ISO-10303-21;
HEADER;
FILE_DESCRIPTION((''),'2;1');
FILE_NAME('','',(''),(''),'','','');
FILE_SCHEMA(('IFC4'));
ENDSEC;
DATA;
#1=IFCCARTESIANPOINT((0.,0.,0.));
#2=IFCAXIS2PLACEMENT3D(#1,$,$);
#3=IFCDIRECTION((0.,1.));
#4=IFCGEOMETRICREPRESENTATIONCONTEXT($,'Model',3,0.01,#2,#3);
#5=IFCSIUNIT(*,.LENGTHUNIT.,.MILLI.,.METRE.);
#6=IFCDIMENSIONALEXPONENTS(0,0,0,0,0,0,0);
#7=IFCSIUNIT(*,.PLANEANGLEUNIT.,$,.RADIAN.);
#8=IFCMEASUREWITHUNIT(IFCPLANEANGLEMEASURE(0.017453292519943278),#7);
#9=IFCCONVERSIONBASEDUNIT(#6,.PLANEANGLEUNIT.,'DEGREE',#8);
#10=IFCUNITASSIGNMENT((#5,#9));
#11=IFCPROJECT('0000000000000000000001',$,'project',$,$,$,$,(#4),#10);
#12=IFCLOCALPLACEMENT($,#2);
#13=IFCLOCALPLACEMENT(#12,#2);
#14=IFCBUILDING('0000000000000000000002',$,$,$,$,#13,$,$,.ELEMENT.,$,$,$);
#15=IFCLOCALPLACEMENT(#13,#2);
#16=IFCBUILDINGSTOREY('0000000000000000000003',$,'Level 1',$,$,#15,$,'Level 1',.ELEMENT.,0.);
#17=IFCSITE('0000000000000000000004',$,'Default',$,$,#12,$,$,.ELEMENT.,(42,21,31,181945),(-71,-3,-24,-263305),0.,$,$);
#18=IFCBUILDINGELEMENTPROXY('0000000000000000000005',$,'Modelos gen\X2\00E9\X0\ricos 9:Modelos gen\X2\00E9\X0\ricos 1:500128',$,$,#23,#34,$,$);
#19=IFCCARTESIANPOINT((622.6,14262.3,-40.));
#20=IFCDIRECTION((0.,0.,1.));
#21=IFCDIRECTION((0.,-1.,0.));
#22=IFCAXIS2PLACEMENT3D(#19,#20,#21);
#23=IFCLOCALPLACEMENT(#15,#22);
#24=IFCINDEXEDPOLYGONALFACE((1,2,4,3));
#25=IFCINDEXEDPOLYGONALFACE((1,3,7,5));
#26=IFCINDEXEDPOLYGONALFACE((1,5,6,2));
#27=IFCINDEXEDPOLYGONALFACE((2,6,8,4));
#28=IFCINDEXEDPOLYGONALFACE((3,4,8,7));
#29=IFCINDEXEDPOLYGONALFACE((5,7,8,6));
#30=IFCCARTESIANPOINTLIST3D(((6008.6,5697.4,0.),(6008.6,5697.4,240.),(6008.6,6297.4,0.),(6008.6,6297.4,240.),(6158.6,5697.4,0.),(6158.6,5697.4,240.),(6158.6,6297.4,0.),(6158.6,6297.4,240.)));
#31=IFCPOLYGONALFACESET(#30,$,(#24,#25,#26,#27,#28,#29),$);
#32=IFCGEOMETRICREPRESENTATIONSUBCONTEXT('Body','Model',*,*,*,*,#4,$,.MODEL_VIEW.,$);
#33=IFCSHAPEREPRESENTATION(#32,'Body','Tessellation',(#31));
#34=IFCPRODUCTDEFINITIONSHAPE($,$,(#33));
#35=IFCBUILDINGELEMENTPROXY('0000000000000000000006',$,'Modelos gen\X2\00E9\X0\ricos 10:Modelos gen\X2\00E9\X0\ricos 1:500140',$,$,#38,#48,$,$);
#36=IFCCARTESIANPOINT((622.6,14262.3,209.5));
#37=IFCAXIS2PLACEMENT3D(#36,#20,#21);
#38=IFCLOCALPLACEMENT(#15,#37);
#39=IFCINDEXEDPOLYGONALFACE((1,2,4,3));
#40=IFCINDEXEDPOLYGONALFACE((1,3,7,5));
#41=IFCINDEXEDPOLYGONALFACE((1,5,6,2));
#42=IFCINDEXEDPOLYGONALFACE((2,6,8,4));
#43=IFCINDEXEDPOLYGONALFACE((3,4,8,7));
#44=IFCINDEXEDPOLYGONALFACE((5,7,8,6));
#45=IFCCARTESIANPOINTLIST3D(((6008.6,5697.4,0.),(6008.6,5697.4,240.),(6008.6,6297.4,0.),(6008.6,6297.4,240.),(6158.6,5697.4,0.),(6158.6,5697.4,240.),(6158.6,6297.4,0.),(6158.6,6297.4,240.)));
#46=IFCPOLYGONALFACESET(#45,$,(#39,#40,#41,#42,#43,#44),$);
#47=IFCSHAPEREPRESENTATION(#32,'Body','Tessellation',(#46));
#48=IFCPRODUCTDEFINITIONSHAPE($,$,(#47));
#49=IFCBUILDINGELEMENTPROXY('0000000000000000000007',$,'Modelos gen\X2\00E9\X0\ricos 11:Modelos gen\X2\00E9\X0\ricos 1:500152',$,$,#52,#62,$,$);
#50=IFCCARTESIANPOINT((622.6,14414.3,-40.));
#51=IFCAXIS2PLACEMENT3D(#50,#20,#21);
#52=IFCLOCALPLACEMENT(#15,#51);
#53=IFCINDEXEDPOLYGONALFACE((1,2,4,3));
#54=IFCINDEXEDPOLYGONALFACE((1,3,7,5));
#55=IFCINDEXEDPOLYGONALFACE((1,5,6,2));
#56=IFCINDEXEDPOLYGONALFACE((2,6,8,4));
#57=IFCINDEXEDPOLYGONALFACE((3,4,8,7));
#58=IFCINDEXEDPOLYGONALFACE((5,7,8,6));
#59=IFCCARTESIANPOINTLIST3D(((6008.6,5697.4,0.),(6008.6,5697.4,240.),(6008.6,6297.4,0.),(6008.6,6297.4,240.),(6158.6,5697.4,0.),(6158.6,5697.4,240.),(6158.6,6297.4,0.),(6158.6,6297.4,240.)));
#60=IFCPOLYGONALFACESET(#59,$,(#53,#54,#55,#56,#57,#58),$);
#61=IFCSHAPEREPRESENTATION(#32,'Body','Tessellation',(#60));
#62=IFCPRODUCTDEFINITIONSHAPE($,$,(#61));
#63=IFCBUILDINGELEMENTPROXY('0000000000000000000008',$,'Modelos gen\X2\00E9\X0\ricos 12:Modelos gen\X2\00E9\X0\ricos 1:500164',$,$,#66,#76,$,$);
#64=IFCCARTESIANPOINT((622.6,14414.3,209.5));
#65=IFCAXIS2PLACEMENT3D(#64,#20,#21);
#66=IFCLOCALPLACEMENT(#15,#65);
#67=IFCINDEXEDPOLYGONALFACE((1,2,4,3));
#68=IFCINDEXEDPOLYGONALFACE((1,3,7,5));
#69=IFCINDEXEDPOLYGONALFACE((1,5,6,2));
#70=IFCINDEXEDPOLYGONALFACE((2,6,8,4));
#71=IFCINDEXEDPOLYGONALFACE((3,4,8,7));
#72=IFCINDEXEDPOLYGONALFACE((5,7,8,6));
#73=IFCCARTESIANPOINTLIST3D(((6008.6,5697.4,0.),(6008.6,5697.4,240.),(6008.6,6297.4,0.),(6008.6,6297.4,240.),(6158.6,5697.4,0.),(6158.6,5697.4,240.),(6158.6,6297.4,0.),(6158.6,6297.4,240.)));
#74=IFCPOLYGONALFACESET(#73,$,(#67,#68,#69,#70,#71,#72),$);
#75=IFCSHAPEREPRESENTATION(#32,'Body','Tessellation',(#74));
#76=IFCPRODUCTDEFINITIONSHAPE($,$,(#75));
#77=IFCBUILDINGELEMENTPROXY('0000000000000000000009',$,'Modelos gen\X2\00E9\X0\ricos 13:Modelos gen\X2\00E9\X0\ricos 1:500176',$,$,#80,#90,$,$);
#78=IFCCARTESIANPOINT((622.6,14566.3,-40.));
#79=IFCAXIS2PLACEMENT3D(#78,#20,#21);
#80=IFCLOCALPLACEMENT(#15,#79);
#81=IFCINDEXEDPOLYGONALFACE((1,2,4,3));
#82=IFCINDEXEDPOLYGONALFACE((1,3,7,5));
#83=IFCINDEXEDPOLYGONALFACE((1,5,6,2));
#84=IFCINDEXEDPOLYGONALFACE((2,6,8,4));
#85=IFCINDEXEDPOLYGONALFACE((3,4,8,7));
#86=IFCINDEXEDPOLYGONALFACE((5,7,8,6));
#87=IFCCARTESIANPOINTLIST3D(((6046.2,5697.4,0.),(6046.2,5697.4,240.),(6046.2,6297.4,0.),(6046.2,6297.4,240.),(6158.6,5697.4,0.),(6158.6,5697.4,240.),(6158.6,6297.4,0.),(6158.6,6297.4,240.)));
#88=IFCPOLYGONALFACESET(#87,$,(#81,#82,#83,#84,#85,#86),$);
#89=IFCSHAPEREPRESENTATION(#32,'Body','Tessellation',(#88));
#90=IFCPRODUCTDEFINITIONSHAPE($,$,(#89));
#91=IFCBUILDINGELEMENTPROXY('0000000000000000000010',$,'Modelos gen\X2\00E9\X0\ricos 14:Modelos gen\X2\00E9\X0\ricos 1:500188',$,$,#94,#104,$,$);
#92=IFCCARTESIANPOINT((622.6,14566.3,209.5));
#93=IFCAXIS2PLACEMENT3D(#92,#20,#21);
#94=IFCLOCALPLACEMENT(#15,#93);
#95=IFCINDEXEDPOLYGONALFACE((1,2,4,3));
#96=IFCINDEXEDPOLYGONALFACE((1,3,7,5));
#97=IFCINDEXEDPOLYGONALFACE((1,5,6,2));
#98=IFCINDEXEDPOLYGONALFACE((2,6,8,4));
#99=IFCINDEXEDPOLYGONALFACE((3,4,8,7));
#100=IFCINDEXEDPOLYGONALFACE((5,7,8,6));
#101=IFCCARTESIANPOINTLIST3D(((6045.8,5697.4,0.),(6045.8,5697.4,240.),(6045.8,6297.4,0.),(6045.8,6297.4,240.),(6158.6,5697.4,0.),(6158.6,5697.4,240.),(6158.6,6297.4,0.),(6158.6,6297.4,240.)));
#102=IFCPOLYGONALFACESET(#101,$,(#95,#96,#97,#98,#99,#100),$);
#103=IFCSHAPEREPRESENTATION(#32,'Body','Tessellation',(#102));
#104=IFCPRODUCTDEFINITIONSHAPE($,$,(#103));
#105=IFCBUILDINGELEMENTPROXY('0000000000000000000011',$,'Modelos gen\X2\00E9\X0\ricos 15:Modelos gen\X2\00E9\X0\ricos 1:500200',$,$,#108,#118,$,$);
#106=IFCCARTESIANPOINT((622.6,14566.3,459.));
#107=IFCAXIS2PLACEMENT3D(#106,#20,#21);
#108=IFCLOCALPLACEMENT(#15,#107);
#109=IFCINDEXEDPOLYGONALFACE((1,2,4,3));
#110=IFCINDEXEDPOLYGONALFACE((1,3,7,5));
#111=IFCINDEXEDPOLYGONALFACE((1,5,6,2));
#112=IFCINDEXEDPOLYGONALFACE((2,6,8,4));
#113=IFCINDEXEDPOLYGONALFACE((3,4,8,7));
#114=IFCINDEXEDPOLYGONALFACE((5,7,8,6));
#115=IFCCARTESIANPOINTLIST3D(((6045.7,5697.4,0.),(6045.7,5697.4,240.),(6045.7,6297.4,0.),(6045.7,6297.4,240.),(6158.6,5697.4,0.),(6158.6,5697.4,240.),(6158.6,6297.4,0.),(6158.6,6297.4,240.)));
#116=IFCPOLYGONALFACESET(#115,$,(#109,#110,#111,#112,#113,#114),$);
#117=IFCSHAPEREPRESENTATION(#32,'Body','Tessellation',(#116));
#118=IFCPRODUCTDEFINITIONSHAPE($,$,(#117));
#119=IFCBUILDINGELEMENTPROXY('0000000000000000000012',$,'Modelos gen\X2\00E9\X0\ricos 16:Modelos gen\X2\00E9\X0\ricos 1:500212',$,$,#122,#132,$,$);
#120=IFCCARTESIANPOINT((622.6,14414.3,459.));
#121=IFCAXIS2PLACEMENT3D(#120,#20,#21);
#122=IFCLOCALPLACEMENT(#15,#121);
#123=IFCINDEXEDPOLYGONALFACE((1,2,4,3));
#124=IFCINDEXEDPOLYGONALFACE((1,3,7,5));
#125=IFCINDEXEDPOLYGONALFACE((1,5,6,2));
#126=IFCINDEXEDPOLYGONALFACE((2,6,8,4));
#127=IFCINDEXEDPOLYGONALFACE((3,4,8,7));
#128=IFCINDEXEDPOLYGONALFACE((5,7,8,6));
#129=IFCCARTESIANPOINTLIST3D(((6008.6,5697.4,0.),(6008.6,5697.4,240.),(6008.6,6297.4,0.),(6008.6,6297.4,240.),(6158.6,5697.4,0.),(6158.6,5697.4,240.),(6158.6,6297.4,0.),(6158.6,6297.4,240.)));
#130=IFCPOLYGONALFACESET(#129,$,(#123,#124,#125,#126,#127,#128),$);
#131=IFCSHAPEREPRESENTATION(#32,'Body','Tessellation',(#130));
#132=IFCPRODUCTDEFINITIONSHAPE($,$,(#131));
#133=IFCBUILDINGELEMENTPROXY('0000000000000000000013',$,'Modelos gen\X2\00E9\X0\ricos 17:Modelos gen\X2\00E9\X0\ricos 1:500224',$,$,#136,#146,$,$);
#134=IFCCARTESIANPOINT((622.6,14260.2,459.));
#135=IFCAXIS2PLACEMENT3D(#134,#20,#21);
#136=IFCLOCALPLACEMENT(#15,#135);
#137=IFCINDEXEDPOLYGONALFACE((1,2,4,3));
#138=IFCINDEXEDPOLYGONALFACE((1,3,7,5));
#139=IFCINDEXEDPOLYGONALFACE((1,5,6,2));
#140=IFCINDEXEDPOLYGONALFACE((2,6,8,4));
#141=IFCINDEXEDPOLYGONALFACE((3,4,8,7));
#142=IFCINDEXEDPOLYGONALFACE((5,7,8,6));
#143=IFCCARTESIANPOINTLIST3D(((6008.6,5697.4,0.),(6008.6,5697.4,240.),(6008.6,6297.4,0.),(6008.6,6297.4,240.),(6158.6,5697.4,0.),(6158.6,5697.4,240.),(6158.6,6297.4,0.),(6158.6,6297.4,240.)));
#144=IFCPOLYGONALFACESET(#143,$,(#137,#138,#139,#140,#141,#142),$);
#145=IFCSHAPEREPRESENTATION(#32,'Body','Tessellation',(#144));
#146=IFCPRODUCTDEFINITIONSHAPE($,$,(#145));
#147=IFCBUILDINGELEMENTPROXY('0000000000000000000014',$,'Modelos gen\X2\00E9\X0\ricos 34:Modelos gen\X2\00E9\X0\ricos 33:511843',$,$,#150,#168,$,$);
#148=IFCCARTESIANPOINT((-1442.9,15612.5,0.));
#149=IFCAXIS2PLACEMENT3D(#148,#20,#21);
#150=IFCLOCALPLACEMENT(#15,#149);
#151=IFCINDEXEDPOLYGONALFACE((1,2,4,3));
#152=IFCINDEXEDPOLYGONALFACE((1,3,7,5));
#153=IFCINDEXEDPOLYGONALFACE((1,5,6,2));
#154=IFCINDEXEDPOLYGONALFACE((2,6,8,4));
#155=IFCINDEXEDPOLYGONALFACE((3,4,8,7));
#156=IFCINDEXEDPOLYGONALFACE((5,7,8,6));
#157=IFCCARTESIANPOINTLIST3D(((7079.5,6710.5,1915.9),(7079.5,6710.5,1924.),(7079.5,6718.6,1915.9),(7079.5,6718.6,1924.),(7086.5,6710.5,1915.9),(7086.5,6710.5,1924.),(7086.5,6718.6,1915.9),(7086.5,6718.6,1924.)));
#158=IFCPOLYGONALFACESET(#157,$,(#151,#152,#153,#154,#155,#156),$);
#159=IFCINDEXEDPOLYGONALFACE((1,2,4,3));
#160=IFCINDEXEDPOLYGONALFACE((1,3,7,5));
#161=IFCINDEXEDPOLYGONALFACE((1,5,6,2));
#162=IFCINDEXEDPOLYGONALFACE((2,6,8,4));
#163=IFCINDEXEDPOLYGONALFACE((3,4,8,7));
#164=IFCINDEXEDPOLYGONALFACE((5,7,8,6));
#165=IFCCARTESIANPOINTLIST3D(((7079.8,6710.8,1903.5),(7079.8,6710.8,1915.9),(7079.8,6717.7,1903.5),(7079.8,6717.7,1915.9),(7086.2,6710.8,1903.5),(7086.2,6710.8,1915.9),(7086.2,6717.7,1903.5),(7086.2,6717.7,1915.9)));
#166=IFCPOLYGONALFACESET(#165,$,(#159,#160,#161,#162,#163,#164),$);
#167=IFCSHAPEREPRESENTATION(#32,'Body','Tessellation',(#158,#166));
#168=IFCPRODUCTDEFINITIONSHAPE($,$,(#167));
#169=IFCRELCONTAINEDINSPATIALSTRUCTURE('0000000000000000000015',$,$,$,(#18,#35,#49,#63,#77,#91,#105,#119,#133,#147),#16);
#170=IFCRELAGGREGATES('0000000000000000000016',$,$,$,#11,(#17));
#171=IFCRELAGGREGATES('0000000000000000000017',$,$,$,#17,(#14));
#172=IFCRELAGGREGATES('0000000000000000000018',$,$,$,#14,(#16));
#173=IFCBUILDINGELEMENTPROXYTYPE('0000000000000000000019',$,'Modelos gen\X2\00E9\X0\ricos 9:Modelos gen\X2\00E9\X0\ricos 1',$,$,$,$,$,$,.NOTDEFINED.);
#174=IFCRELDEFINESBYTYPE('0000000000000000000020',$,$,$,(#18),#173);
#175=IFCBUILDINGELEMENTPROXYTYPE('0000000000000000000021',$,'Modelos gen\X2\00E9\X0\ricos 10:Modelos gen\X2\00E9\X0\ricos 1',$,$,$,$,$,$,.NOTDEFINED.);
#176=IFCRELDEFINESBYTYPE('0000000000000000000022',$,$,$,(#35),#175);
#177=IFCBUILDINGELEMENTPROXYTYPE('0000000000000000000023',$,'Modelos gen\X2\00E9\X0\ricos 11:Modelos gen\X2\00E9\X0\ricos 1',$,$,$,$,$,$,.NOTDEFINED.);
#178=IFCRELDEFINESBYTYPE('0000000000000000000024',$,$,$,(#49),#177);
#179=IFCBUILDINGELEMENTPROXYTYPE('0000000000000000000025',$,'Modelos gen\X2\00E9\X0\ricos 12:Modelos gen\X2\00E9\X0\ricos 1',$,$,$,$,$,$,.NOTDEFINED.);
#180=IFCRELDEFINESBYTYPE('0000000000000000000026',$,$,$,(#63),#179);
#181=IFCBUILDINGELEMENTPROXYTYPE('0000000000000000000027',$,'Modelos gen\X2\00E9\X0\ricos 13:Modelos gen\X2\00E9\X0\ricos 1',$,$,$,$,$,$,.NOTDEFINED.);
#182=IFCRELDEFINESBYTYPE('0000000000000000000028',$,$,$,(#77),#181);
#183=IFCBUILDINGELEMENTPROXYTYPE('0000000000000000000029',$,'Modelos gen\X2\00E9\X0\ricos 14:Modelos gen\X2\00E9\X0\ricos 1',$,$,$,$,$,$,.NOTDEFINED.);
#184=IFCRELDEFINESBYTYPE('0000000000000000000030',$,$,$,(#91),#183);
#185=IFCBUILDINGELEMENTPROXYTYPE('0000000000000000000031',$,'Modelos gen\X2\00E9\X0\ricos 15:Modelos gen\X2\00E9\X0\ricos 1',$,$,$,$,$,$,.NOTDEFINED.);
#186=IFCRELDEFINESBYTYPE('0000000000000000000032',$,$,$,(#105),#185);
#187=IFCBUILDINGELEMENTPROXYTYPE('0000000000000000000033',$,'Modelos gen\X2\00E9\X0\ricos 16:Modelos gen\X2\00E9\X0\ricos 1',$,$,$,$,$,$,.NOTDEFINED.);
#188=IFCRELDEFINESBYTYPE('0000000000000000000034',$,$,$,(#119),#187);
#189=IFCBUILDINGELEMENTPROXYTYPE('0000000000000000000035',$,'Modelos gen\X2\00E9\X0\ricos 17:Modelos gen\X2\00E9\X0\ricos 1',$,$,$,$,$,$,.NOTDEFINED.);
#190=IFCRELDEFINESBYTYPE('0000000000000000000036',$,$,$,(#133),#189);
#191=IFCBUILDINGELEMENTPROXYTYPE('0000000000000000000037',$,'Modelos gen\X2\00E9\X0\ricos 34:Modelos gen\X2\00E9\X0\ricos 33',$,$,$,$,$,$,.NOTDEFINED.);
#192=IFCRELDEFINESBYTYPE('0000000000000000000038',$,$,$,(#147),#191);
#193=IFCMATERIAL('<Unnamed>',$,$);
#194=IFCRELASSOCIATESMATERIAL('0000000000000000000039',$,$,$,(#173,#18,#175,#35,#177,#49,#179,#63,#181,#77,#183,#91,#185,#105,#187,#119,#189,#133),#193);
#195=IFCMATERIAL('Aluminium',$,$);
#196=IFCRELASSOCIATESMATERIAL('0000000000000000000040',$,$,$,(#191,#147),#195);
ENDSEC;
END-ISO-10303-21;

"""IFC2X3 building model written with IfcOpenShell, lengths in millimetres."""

from ifc_helpers import new_model, entity, si_unit, converted_unit, direction, frame, frame_2d, origin, origin_2d_with_axis, place, context, subcontext, project, spatial, rectangle, extrude, source, transform, mapped, material, type_object, type_shapes, element, save


model = new_model("IFC2X3")

# Units and contexts
model_context = context("Model", 3, precision=0.01, world=origin(), true_north=direction((0.0, 1.0)))
body_context = subcontext(model_context, "Body", "Model", "MODEL_VIEW")
ifc_project = project(units=[si_unit("LENGTHUNIT", "METRE", prefix="MILLI"), converted_unit("PLANEANGLEUNIT", "DEGREE", entity("IfcPlaneAngleMeasure", 0.017453292519943278), si_unit("PLANEANGLEUNIT", "RADIAN"), dimensions=[0, 0, 0, 0, 0, 0, 0])], contexts=[model_context])

# Site, building, storey
site_placement = place(None, origin())
site = spatial("IfcSite", under=ifc_project, at=site_placement, Name="Default", CompositionType="ELEMENT", RefLatitude=(42, 21, 31, 181945), RefLongitude=(-71, -3, -24, -263305), RefElevation=0.0)
building_placement = place(site_placement, origin())
building = spatial("IfcBuilding", under=site, at=building_placement, CompositionType="ELEMENT")
storey_placement = place(building_placement, origin())
storey = spatial("IfcBuildingStorey", under=building, at=storey_placement, Name="Level 1", LongName="Level 1", CompositionType="ELEMENT", Elevation=0.0)

# Building element proxies
ifc_material_1 = material(Name="<Unnamed>")
building_element_proxy_type_1 = type_object("IfcBuildingElementProxyType", Name="Modelos genéricos 9:Modelos genéricos 1", PredefinedType="NOTDEFINED", material=ifc_material_1)
shared_shape_1 = source(origin(), body_context, "Body", "SweptSolid", [
    extrude(rectangle(XDim=150.0, YDim=600.0, at=origin_2d_with_axis()), frame((6083.6, 5997.4, 0.0), z_axis=(0.0, 0.0, 1.0), x_axis=(-1.0, 0.0, 0.0)), (0.0, 0.0, 1.0), 240.0),
])
type_shapes(building_element_proxy_type_1, [shared_shape_1])
proxy_1_placement = place(storey_placement, frame((622.6, 14262.3, -40.0), z_axis=(0.0, 0.0, 1.0), x_axis=(0.0, -1.0, 0.0)))
element("IfcBuildingElementProxy", 1, at=proxy_1_placement, inside=storey, type_object=building_element_proxy_type_1, material=ifc_material_1, Name="Modelos genéricos 9:Modelos genéricos 1:500128", context=body_context, shape_type="MappedRepresentation", body=[
    mapped(shared_shape_1, transform((0.0, 0.0, 0.0), scale=1.0)),
])
building_element_proxy_type_2 = type_object("IfcBuildingElementProxyType", Name="Modelos genéricos 10:Modelos genéricos 1", PredefinedType="NOTDEFINED", material=ifc_material_1)
shared_shape_2 = source(origin(), body_context, "Body", "SweptSolid", [
    extrude(rectangle(XDim=150.0, YDim=600.0, at=origin_2d_with_axis()), frame((6083.6, 5997.4, 0.0), z_axis=(0.0, 0.0, 1.0), x_axis=(-1.0, 0.0, 0.0)), (0.0, 0.0, 1.0), 240.0),
])
type_shapes(building_element_proxy_type_2, [shared_shape_2])
proxy_2_placement = place(storey_placement, frame((622.6, 14262.3, 209.5), z_axis=(0.0, 0.0, 1.0), x_axis=(0.0, -1.0, 0.0)))
element("IfcBuildingElementProxy", 2, at=proxy_2_placement, inside=storey, type_object=building_element_proxy_type_2, material=ifc_material_1, Name="Modelos genéricos 10:Modelos genéricos 1:500140", context=body_context, shape_type="MappedRepresentation", body=[
    mapped(shared_shape_2, transform((0.0, 0.0, 0.0), scale=1.0)),
])
building_element_proxy_type_3 = type_object("IfcBuildingElementProxyType", Name="Modelos genéricos 11:Modelos genéricos 1", PredefinedType="NOTDEFINED", material=ifc_material_1)
shared_shape_3 = source(origin(), body_context, "Body", "SweptSolid", [
    extrude(rectangle(XDim=150.0, YDim=600.0, at=origin_2d_with_axis()), frame((6083.6, 5997.4, 0.0), z_axis=(0.0, 0.0, 1.0), x_axis=(-1.0, 0.0, 0.0)), (0.0, 0.0, 1.0), 240.0),
])
type_shapes(building_element_proxy_type_3, [shared_shape_3])
proxy_3_placement = place(storey_placement, frame((622.6, 14414.3, -40.0), z_axis=(0.0, 0.0, 1.0), x_axis=(0.0, -1.0, 0.0)))
element("IfcBuildingElementProxy", 3, at=proxy_3_placement, inside=storey, type_object=building_element_proxy_type_3, material=ifc_material_1, Name="Modelos genéricos 11:Modelos genéricos 1:500152", context=body_context, shape_type="MappedRepresentation", body=[
    mapped(shared_shape_3, transform((0.0, 0.0, 0.0), scale=1.0)),
])
building_element_proxy_type_4 = type_object("IfcBuildingElementProxyType", Name="Modelos genéricos 12:Modelos genéricos 1", PredefinedType="NOTDEFINED", material=ifc_material_1)
shared_shape_4 = source(origin(), body_context, "Body", "SweptSolid", [
    extrude(rectangle(XDim=150.0, YDim=600.0, at=origin_2d_with_axis()), frame((6083.6, 5997.4, 0.0), z_axis=(0.0, 0.0, 1.0), x_axis=(-1.0, 0.0, 0.0)), (0.0, 0.0, 1.0), 240.0),
])
type_shapes(building_element_proxy_type_4, [shared_shape_4])
proxy_4_placement = place(storey_placement, frame((622.6, 14414.3, 209.5), z_axis=(0.0, 0.0, 1.0), x_axis=(0.0, -1.0, 0.0)))
element("IfcBuildingElementProxy", 4, at=proxy_4_placement, inside=storey, type_object=building_element_proxy_type_4, material=ifc_material_1, Name="Modelos genéricos 12:Modelos genéricos 1:500164", context=body_context, shape_type="MappedRepresentation", body=[
    mapped(shared_shape_4, transform((0.0, 0.0, 0.0), scale=1.0)),
])
building_element_proxy_type_5 = type_object("IfcBuildingElementProxyType", Name="Modelos genéricos 13:Modelos genéricos 1", PredefinedType="NOTDEFINED", material=ifc_material_1)
shared_shape_5 = source(origin(), body_context, "Body", "SweptSolid", [
    extrude(rectangle(XDim=112.4, YDim=600.0, at=frame_2d((0.0, 0.0), x_axis=(1.0, 0.0))), frame((6102.4, 5997.4, 0.0), z_axis=(0.0, 0.0, 1.0), x_axis=(-1.0, 0.0, 0.0)), (0.0, 0.0, 1.0), 240.0),
])
type_shapes(building_element_proxy_type_5, [shared_shape_5])
proxy_5_placement = place(storey_placement, frame((622.6, 14566.3, -40.0), z_axis=(0.0, 0.0, 1.0), x_axis=(0.0, -1.0, 0.0)))
element("IfcBuildingElementProxy", 5, at=proxy_5_placement, inside=storey, type_object=building_element_proxy_type_5, material=ifc_material_1, Name="Modelos genéricos 13:Modelos genéricos 1:500176", context=body_context, shape_type="MappedRepresentation", body=[
    mapped(shared_shape_5, transform((0.0, 0.0, 0.0), scale=1.0)),
])
building_element_proxy_type_6 = type_object("IfcBuildingElementProxyType", Name="Modelos genéricos 14:Modelos genéricos 1", PredefinedType="NOTDEFINED", material=ifc_material_1)
shared_shape_6 = source(origin(), body_context, "Body", "SweptSolid", [
    extrude(rectangle(XDim=112.8, YDim=600.0, at=frame_2d((0.0, 0.0), x_axis=(1.0, 0.0))), frame((6102.2, 5997.4, 0.0), z_axis=(0.0, 0.0, 1.0), x_axis=(-1.0, 0.0, 0.0)), (0.0, 0.0, 1.0), 240.0),
])
type_shapes(building_element_proxy_type_6, [shared_shape_6])
proxy_6_placement = place(storey_placement, frame((622.6, 14566.3, 209.5), z_axis=(0.0, 0.0, 1.0), x_axis=(0.0, -1.0, 0.0)))
element("IfcBuildingElementProxy", 6, at=proxy_6_placement, inside=storey, type_object=building_element_proxy_type_6, material=ifc_material_1, Name="Modelos genéricos 14:Modelos genéricos 1:500188", context=body_context, shape_type="MappedRepresentation", body=[
    mapped(shared_shape_6, transform((0.0, 0.0, 0.0), scale=1.0)),
])
building_element_proxy_type_7 = type_object("IfcBuildingElementProxyType", Name="Modelos genéricos 15:Modelos genéricos 1", PredefinedType="NOTDEFINED", material=ifc_material_1)
shared_shape_7 = source(origin(), body_context, "Body", "SweptSolid", [
    extrude(rectangle(XDim=112.9, YDim=600.0, at=origin_2d_with_axis()), frame((6102.2, 5997.4, 0.0), z_axis=(0.0, 0.0, 1.0), x_axis=(-1.0, 0.0, 0.0)), (0.0, 0.0, 1.0), 240.0),
])
type_shapes(building_element_proxy_type_7, [shared_shape_7])
proxy_7_placement = place(storey_placement, frame((622.6, 14566.3, 459.0), z_axis=(0.0, 0.0, 1.0), x_axis=(0.0, -1.0, 0.0)))
element("IfcBuildingElementProxy", 7, at=proxy_7_placement, inside=storey, type_object=building_element_proxy_type_7, material=ifc_material_1, Name="Modelos genéricos 15:Modelos genéricos 1:500200", context=body_context, shape_type="MappedRepresentation", body=[
    mapped(shared_shape_7, transform((0.0, 0.0, 0.0), scale=1.0)),
])
building_element_proxy_type_8 = type_object("IfcBuildingElementProxyType", Name="Modelos genéricos 16:Modelos genéricos 1", PredefinedType="NOTDEFINED", material=ifc_material_1)
shared_shape_8 = source(origin(), body_context, "Body", "SweptSolid", [
    extrude(rectangle(XDim=150.0, YDim=600.0, at=origin_2d_with_axis()), frame((6083.6, 5997.4, 0.0), z_axis=(0.0, 0.0, 1.0), x_axis=(-1.0, 0.0, 0.0)), (0.0, 0.0, 1.0), 240.0),
])
type_shapes(building_element_proxy_type_8, [shared_shape_8])
proxy_8_placement = place(storey_placement, frame((622.6, 14414.3, 459.0), z_axis=(0.0, 0.0, 1.0), x_axis=(0.0, -1.0, 0.0)))
element("IfcBuildingElementProxy", 8, at=proxy_8_placement, inside=storey, type_object=building_element_proxy_type_8, material=ifc_material_1, Name="Modelos genéricos 16:Modelos genéricos 1:500212", context=body_context, shape_type="MappedRepresentation", body=[
    mapped(shared_shape_8, transform((0.0, 0.0, 0.0), scale=1.0)),
])
building_element_proxy_type_9 = type_object("IfcBuildingElementProxyType", Name="Modelos genéricos 17:Modelos genéricos 1", PredefinedType="NOTDEFINED", material=ifc_material_1)
shared_shape_9 = source(origin(), body_context, "Body", "SweptSolid", [
    extrude(rectangle(XDim=150.0, YDim=600.0, at=origin_2d_with_axis()), frame((6083.6, 5997.4, 0.0), z_axis=(0.0, 0.0, 1.0), x_axis=(-1.0, 0.0, 0.0)), (0.0, 0.0, 1.0), 240.0),
])
type_shapes(building_element_proxy_type_9, [shared_shape_9])
proxy_9_placement = place(storey_placement, frame((622.6, 14260.2, 459.0), z_axis=(0.0, 0.0, 1.0), x_axis=(0.0, -1.0, 0.0)))
element("IfcBuildingElementProxy", 9, at=proxy_9_placement, inside=storey, type_object=building_element_proxy_type_9, material=ifc_material_1, Name="Modelos genéricos 17:Modelos genéricos 1:500224", context=body_context, shape_type="MappedRepresentation", body=[
    mapped(shared_shape_9, transform((0.0, 0.0, 0.0), scale=1.0)),
])
ifc_material_2 = material(Name="Aluminium")
building_element_proxy_type_10 = type_object("IfcBuildingElementProxyType", Name="Modelos genéricos 34:Modelos genéricos 33", PredefinedType="NOTDEFINED", material=ifc_material_2)
shared_shape_10 = source(origin(), body_context, "Body", "SweptSolid", [
    extrude(rectangle(XDim=8.2, YDim=7.0, at=frame_2d((0.0, 0.0), x_axis=(1.0, 0.0))), frame((7083.0, 6714.5, 1915.9), z_axis=(0.0, 0.0, 1.0), x_axis=(0.0, 1.0, 0.0)), (0.0, 0.0, 1.0), 8.1),
    extrude(rectangle(XDim=6.9, YDim=6.4, at=frame_2d((0.0, 0.0), x_axis=(1.0, 0.0))), frame((7083.0, 6714.2, 1903.5), z_axis=(0.0, 0.0, 1.0), x_axis=(0.0, 1.0, 0.0)), (0.0, 0.0, 1.0), 12.3),
])
type_shapes(building_element_proxy_type_10, [shared_shape_10])
proxy_10_placement = place(storey_placement, frame((-1442.9, 15612.5, 0.0), z_axis=(0.0, 0.0, 1.0), x_axis=(0.0, -1.0, 0.0)))
element("IfcBuildingElementProxy", 10, at=proxy_10_placement, inside=storey, type_object=building_element_proxy_type_10, material=ifc_material_2, Name="Modelos genéricos 34:Modelos genéricos 33:511843", context=body_context, shape_type="MappedRepresentation", body=[
    mapped(shared_shape_10, transform((0.0, 0.0, 0.0), scale=1.0)),
])

save(model, "model.ifc")
